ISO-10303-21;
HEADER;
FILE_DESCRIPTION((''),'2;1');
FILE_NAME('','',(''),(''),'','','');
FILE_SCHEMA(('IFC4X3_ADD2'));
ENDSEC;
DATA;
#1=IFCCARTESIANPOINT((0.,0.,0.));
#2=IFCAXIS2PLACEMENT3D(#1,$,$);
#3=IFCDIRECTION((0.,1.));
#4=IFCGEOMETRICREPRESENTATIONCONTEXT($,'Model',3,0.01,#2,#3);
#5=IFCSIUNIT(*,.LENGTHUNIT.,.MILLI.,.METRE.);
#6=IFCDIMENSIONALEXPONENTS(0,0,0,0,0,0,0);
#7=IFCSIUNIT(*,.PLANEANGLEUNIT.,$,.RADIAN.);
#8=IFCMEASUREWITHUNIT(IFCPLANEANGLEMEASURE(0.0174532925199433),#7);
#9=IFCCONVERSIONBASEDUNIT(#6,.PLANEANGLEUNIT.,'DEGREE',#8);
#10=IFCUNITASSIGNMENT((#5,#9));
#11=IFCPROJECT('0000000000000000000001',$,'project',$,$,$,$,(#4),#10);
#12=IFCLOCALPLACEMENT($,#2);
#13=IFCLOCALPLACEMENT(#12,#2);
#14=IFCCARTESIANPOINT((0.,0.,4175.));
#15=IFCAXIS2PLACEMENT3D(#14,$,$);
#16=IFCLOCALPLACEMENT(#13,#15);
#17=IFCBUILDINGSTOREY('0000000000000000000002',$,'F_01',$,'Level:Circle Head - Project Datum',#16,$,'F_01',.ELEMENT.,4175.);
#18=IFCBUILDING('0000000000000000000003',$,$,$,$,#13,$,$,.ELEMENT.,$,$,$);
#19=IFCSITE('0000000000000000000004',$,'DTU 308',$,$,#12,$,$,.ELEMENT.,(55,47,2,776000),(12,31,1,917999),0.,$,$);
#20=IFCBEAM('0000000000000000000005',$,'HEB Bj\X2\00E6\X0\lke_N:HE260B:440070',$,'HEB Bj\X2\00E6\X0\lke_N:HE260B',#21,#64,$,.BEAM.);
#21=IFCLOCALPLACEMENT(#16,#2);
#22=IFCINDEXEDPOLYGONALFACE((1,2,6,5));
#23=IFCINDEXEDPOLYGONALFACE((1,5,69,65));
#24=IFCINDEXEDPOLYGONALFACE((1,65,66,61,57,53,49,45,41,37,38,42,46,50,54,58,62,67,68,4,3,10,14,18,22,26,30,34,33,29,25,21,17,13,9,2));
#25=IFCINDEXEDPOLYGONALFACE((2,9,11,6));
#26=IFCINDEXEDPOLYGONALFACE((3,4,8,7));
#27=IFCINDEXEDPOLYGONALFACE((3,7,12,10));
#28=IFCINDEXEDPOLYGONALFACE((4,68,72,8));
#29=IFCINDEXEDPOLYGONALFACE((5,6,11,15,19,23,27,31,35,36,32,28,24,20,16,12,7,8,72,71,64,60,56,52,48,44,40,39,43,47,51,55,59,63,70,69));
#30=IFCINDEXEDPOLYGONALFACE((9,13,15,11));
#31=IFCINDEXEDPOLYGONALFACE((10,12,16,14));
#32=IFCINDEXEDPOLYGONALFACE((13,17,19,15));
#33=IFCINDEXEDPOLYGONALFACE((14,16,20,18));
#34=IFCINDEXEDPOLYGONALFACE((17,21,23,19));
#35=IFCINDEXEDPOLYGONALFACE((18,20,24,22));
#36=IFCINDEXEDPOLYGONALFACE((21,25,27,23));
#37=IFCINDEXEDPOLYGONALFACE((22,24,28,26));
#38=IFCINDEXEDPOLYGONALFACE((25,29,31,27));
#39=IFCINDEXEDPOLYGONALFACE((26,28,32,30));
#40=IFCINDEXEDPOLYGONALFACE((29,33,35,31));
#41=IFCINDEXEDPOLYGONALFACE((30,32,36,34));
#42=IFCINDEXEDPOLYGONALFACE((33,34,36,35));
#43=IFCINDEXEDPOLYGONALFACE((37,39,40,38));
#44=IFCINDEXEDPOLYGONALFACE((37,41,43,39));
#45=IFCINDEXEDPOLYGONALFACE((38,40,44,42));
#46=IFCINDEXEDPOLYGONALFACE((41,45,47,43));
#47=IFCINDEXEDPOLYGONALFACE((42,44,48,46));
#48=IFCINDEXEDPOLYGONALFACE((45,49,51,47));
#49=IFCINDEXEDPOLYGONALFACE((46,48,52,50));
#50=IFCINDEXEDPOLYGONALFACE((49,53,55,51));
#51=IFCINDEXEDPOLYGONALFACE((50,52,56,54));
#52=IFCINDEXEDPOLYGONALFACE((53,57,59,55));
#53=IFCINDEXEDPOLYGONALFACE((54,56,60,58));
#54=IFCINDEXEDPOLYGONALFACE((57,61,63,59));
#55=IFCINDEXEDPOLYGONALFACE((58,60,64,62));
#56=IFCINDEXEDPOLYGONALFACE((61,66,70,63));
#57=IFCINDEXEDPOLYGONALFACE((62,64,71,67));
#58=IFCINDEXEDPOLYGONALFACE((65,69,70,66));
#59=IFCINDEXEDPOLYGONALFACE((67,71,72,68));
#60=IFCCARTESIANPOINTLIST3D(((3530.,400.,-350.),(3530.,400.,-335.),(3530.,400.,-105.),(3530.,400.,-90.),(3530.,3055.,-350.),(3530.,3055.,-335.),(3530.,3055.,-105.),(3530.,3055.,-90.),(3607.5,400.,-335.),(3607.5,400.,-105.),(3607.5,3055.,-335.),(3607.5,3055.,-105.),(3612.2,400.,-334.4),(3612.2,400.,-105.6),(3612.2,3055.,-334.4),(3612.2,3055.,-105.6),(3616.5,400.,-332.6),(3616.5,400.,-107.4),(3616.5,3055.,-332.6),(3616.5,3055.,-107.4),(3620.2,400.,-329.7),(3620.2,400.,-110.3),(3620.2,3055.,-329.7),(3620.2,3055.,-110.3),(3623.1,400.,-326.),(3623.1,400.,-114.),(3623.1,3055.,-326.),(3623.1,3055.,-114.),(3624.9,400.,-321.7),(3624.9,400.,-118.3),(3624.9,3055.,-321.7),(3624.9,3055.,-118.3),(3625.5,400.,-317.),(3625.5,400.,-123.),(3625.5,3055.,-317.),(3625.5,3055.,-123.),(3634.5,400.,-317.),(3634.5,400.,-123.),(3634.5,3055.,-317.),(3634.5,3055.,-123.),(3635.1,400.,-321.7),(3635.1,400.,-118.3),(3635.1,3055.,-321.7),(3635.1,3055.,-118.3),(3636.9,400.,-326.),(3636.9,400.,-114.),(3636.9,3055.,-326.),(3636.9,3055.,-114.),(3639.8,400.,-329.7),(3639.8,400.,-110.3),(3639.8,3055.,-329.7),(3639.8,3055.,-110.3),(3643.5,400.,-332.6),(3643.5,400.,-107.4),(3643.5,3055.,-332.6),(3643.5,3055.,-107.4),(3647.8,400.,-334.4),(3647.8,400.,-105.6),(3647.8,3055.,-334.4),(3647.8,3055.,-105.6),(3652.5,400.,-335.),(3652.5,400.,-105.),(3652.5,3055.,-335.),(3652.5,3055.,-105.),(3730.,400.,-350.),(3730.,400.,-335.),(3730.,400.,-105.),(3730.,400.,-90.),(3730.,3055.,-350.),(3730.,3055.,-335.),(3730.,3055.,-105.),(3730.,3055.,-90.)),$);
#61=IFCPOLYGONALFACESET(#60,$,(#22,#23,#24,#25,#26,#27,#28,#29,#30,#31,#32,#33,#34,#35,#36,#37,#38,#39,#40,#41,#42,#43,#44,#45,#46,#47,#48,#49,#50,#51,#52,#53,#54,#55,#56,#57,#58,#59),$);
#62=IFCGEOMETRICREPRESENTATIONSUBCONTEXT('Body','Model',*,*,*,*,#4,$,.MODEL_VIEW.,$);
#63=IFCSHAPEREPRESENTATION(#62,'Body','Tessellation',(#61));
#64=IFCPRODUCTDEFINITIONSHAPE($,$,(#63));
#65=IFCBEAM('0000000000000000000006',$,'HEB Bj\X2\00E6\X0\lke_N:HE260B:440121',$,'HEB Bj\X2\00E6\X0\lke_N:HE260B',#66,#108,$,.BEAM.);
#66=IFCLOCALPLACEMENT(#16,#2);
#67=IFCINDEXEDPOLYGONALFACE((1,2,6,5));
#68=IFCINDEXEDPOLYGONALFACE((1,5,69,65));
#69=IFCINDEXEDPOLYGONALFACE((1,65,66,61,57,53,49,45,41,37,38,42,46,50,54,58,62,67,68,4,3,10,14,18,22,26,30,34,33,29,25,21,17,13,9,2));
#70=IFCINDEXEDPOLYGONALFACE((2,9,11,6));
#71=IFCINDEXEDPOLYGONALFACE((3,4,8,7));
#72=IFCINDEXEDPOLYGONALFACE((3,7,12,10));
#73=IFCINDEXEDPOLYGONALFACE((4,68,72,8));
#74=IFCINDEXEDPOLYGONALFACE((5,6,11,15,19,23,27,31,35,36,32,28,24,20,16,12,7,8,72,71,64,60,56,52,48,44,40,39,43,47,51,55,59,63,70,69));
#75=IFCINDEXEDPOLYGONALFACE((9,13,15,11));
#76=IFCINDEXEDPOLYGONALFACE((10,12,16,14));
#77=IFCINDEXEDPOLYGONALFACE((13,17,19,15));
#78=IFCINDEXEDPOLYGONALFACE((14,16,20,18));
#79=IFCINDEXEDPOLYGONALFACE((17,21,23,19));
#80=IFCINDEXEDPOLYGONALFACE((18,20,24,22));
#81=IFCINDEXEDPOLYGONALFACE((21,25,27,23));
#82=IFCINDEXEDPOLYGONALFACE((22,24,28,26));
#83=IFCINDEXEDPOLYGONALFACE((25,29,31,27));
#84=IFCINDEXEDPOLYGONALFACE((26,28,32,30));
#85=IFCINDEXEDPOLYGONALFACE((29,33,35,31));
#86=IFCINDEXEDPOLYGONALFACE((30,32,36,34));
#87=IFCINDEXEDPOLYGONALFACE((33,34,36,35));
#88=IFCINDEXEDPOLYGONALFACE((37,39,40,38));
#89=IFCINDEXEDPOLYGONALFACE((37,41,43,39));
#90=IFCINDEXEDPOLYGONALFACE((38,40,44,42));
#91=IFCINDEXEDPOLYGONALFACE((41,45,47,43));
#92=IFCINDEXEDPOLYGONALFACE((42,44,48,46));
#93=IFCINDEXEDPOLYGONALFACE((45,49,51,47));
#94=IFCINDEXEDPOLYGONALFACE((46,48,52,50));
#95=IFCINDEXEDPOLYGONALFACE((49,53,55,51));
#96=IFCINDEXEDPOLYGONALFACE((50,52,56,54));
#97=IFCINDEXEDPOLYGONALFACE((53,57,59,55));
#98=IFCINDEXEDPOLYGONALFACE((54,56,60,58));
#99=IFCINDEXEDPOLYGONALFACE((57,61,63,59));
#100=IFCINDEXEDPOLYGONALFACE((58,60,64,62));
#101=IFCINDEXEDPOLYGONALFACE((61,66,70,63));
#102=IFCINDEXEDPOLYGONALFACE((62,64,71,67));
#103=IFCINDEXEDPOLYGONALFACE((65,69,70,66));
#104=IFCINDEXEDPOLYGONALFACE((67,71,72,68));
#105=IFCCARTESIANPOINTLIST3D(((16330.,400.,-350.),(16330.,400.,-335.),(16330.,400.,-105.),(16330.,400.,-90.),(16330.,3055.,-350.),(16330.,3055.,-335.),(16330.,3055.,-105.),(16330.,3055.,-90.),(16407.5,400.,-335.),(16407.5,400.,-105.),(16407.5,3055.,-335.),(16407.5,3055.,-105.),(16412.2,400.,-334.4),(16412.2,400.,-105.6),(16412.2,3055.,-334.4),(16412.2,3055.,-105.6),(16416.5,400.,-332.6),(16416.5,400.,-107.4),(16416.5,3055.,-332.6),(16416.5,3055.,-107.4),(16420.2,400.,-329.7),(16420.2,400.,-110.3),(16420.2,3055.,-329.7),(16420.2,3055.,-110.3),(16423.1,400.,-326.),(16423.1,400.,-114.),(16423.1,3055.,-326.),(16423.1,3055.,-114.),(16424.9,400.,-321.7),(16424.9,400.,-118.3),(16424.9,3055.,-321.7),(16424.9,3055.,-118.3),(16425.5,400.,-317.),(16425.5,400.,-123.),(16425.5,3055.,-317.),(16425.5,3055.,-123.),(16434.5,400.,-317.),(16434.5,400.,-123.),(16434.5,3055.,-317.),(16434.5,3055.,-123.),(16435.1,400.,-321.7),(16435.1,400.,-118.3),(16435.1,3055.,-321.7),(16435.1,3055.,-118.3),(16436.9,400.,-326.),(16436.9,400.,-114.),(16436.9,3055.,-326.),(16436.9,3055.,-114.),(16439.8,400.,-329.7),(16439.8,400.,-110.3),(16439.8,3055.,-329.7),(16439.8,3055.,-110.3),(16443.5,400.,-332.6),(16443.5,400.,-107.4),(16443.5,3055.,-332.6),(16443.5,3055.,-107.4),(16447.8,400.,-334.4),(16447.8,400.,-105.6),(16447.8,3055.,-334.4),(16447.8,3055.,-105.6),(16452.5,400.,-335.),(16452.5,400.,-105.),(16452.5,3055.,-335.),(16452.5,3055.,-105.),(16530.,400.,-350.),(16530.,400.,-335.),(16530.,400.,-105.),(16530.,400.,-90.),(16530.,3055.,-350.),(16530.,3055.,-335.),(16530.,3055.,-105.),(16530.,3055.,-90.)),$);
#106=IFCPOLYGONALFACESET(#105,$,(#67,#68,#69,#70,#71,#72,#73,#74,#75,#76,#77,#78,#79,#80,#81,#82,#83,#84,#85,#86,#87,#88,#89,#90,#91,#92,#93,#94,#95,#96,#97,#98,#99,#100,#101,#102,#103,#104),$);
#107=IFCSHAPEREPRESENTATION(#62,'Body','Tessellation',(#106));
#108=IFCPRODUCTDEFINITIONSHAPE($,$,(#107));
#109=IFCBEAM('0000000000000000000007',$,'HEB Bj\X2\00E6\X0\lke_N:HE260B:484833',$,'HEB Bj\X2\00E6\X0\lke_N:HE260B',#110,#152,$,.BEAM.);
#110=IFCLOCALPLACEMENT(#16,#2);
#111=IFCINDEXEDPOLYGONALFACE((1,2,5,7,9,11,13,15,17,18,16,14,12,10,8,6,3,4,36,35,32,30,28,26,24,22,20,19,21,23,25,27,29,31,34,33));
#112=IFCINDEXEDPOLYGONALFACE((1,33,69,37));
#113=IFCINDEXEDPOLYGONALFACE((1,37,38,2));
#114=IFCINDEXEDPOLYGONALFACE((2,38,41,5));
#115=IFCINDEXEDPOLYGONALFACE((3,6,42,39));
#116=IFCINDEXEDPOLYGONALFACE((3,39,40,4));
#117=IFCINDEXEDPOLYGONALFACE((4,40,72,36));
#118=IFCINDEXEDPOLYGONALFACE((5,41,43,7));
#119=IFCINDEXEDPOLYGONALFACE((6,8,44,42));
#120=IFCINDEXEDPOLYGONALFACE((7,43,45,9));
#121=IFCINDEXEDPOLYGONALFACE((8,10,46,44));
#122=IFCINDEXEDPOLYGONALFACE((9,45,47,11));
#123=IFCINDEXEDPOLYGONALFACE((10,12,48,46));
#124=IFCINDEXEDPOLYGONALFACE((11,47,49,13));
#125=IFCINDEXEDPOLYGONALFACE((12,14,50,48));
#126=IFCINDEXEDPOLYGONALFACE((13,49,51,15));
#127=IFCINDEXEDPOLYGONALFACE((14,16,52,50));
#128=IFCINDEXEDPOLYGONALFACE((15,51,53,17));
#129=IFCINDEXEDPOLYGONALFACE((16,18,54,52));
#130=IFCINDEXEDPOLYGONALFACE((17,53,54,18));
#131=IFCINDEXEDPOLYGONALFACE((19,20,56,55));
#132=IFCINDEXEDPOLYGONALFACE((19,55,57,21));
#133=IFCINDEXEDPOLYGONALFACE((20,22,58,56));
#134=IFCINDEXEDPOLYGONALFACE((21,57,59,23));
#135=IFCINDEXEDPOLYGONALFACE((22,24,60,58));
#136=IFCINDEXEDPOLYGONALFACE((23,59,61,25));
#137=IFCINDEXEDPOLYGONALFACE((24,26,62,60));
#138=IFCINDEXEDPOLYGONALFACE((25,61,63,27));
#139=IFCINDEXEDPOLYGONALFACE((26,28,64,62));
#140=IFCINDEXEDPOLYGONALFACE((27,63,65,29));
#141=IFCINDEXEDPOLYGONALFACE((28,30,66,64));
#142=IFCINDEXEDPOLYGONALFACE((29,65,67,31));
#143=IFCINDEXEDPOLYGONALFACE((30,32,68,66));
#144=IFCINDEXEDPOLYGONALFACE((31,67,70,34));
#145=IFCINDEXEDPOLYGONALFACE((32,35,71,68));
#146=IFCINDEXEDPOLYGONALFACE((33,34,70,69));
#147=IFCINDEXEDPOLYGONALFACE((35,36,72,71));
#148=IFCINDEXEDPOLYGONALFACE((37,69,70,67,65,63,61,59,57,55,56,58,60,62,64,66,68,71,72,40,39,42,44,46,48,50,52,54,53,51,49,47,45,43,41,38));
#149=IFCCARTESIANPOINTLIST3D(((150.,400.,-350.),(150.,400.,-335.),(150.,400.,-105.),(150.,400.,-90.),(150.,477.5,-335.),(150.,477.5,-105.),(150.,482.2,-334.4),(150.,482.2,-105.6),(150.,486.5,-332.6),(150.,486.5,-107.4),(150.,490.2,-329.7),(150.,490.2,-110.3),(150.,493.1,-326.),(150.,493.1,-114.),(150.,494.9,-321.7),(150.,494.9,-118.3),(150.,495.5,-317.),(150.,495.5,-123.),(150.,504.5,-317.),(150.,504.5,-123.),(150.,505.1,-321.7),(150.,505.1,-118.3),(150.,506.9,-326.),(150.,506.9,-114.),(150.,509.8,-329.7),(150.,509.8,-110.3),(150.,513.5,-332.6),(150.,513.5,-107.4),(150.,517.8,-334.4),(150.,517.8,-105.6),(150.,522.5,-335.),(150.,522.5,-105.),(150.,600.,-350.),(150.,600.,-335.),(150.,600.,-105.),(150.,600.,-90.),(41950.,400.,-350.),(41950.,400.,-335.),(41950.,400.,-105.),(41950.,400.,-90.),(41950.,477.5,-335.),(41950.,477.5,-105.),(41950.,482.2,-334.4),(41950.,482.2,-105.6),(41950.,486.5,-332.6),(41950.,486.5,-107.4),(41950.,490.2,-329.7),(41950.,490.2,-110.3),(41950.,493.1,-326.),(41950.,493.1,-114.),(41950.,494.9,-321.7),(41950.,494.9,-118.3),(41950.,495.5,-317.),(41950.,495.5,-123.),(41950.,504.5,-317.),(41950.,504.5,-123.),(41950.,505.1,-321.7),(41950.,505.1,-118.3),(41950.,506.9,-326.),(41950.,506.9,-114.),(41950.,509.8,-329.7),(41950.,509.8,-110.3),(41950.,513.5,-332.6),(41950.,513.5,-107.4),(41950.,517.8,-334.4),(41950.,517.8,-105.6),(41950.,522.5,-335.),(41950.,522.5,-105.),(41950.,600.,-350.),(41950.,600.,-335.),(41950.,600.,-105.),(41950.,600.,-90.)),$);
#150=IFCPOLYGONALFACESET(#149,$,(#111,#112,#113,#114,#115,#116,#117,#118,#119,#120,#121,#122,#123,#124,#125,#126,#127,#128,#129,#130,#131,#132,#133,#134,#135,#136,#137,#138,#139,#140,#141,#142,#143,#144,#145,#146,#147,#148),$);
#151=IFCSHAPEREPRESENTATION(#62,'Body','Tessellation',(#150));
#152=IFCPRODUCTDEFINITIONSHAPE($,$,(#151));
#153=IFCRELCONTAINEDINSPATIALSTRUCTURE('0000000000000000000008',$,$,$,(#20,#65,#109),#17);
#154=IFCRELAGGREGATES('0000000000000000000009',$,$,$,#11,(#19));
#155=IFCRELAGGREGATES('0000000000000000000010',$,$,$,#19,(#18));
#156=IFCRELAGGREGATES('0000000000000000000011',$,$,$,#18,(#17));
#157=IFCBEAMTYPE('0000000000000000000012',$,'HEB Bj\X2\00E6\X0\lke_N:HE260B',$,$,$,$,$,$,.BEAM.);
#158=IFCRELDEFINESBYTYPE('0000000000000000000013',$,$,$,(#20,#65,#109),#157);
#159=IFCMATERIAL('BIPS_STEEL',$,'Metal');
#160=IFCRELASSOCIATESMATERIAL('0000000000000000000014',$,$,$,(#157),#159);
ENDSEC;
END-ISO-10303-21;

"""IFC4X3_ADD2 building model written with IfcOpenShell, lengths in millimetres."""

from ifc_helpers import new_model, entity, si_unit, converted_unit, direction, frame, frame_2d, origin, place, context, subcontext, project, spatial, polyline, circle_curve, parameter, trimmed, segment, composite_curve, i_section, outline, extrude, source, transform, mapped, material, material_profile, profile_set, type_object, element, save


model = new_model("IFC4X3_ADD2")

# Units and contexts
model_context = context("Model", 3, precision=0.01, world=origin(), true_north=direction((0.0, 1.0)))
body_context = subcontext(model_context, "Body", "Model", "MODEL_VIEW")
ifc_project = project(units=[si_unit("LENGTHUNIT", "METRE", prefix="MILLI"), converted_unit("PLANEANGLEUNIT", "DEGREE", entity("IfcPlaneAngleMeasure", 0.0174532925199433), si_unit("PLANEANGLEUNIT", "RADIAN"), dimensions=[0, 0, 0, 0, 0, 0, 0])], contexts=[model_context])

# Site, building, storey
site_placement = place(None, origin())
site = spatial("IfcSite", under=ifc_project, at=site_placement, Name="DTU 308", CompositionType="ELEMENT", RefLatitude=(55, 47, 2, 776000), RefLongitude=(12, 31, 1, 917999), RefElevation=0.0)
building_placement = place(site_placement, origin())
building = spatial("IfcBuilding", under=site, at=building_placement, CompositionType="ELEMENT")
storey_placement = place(building_placement, frame((0.0, 0.0, 4175.0)))
storey = spatial("IfcBuildingStorey", under=building, at=storey_placement, Name="F_01", ObjectType="Level:Circle Head - Project Datum", LongName="F_01", CompositionType="ELEMENT", Elevation=4175.0)

# Shared definitions
ifc_material_1 = material(Name="BIPS_STEEL", Category="Metal")

# Beams
ifc_material_profile_1 = material_profile(ifc_material_1, i_section(OverallWidth=200.0, OverallDepth=260.0, WebThickness=9.0, FlangeThickness=15.0, FilletRadius=18.0, at=frame_2d((0.0, 0.0), x_axis=(1.0, 0.0))), Name="HE260B")
ifc_profile_set_1 = profile_set([ifc_material_profile_1], Name="HE260B")
beam_type = type_object("IfcBeamType", Name="HEB Bjælke_N:HE260B", PredefinedType="BEAM", material=ifc_profile_set_1)
shared_shape_1 = source(origin(), body_context, "Body", "SweptSolid", [
    extrude(outline(composite_curve([segment(polyline([(-100.0, -115.0), (-100.0, -130.0)]), True, "CONTINUOUS"), segment(polyline([(-100.0, -130.0), (100.0, -130.0)]), True, "CONTINUOUS"), segment(polyline([(100.0, -130.0), (100.0, -115.0)]), True, "CONTINUOUS"), segment(polyline([(100.0, -115.0), (22.5, -115.0)]), True, "CONTINUOUS"), segment(trimmed(circle_curve(frame_2d((22.5, -97.0), x_axis=(1.0, 0.0)), 18.0), [parameter(180.0)], [parameter(270.0)], True, "PARAMETER"), False, "CONTINUOUS"), segment(polyline([(4.5, -97.0), (4.5, 97.0)]), True, "CONTINUOUS"), segment(trimmed(circle_curve(frame_2d((22.5, 97.0), x_axis=(1.0, 0.0)), 18.0), [parameter(90.0)], [parameter(180.0)], True, "PARAMETER"), False, "CONTINUOUS"), segment(polyline([(22.5, 115.0), (100.0, 115.0)]), True, "CONTINUOUS"), segment(polyline([(100.0, 115.0), (100.0, 130.0)]), True, "CONTINUOUS"), segment(polyline([(100.0, 130.0), (-100.0, 130.0)]), True, "CONTINUOUS"), segment(polyline([(-100.0, 130.0), (-100.0, 115.0)]), True, "CONTINUOUS"), segment(polyline([(-100.0, 115.0), (-22.5, 115.0)]), True, "CONTINUOUS"), segment(trimmed(circle_curve(frame_2d((-22.5, 97.0), x_axis=(1.0, 0.0)), 18.0), [parameter(360.0)], [parameter(90.0)], True, "PARAMETER"), False, "CONTINUOUS"), segment(polyline([(-4.5, 97.0), (-4.5, -97.0)]), True, "CONTINUOUS"), segment(trimmed(circle_curve(frame_2d((-22.5, -97.0), x_axis=(1.0, 0.0)), 18.0), [parameter(270.0)], [parameter(360.0)], True, "PARAMETER"), False, "CONTINUOUS"), segment(polyline([(-22.5, -115.0), (-100.0, -115.0)]), True, "CONTINUOUS")], self_intersect=False)), frame((-1227.5, 0.0, 0.0), z_axis=(-1.0, 0.0, 0.0), x_axis=(0.0, -1.0, 0.0)), (0.0, 0.0, -1.0), 2655.0),
])
for number, where, z_axis, x_axis, name in (
    (1, (3630.0, 1827.5, -220.0), (0.0, 0.0, 1.0), (0.0, -1.0, 0.0), "HEB Bjælke_N:HE260B:440070"),
    (2, (16430.0, 1827.5, -220.0), (0.0, 0.0, 1.0), (0.0, -1.0, 0.0), "HEB Bjælke_N:HE260B:440121"),
):
    element("IfcBeam", number, at=place(storey_placement, frame(where, z_axis=z_axis, x_axis=x_axis)), inside=storey, type_object=beam_type, Name=name, ObjectType="HEB Bjælke_N:HE260B", PredefinedType="BEAM", context=body_context, shape_type="MappedRepresentation", body=[
        mapped(shared_shape_1, transform((0.0, 0.0, 0.0), scale=1.0)),
    ])
shared_shape_2 = source(origin(), body_context, "Body", "SweptSolid", [
    extrude(outline(composite_curve([segment(polyline([(-100.0, -115.0), (-100.0, -130.0)]), True, "CONTINUOUS"), segment(polyline([(-100.0, -130.0), (100.0, -130.0)]), True, "CONTINUOUS"), segment(polyline([(100.0, -130.0), (100.0, -115.0)]), True, "CONTINUOUS"), segment(polyline([(100.0, -115.0), (22.5, -115.0)]), True, "CONTINUOUS"), segment(trimmed(circle_curve(frame_2d((22.5, -97.0), x_axis=(1.0, 0.0)), 18.0), [parameter(180.0)], [parameter(270.0)], True, "PARAMETER"), False, "CONTINUOUS"), segment(polyline([(4.5, -97.0), (4.5, 97.0)]), True, "CONTINUOUS"), segment(trimmed(circle_curve(frame_2d((22.5, 97.0), x_axis=(1.0, 0.0)), 18.0), [parameter(90.0)], [parameter(180.0)], True, "PARAMETER"), False, "CONTINUOUS"), segment(polyline([(22.5, 115.0), (100.0, 115.0)]), True, "CONTINUOUS"), segment(polyline([(100.0, 115.0), (100.0, 130.0)]), True, "CONTINUOUS"), segment(polyline([(100.0, 130.0), (-100.0, 130.0)]), True, "CONTINUOUS"), segment(polyline([(-100.0, 130.0), (-100.0, 115.0)]), True, "CONTINUOUS"), segment(polyline([(-100.0, 115.0), (-22.5, 115.0)]), True, "CONTINUOUS"), segment(trimmed(circle_curve(frame_2d((-22.5, 97.0), x_axis=(1.0, 0.0)), 18.0), [parameter(360.0)], [parameter(90.0)], True, "PARAMETER"), False, "CONTINUOUS"), segment(polyline([(-4.5, 97.0), (-4.5, -97.0)]), True, "CONTINUOUS"), segment(trimmed(circle_curve(frame_2d((-22.5, -97.0), x_axis=(1.0, 0.0)), 18.0), [parameter(270.0)], [parameter(360.0)], True, "PARAMETER"), False, "CONTINUOUS"), segment(polyline([(-22.5, -115.0), (-100.0, -115.0)]), True, "CONTINUOUS")], self_intersect=False)), frame((-20670.0, 0.0, 0.0), z_axis=(-1.0, 0.0, 0.0), x_axis=(0.0, -1.0, 0.0)), (0.0, 0.0, -1.0), 41800.0),
])
beam_placement = place(storey_placement, frame((21280.0, 500.0, -220.0), z_axis=(0.0, 0.0, 1.0), x_axis=(-1.0, 0.0, 0.0)))
element("IfcBeam", 3, at=beam_placement, inside=storey, type_object=beam_type, Name="HEB Bjælke_N:HE260B:484833", ObjectType="HEB Bjælke_N:HE260B", PredefinedType="BEAM", context=body_context, shape_type="MappedRepresentation", body=[
    mapped(shared_shape_2, transform((0.0, 0.0, 0.0), scale=1.0)),
])

save(model, "model.ifc")
